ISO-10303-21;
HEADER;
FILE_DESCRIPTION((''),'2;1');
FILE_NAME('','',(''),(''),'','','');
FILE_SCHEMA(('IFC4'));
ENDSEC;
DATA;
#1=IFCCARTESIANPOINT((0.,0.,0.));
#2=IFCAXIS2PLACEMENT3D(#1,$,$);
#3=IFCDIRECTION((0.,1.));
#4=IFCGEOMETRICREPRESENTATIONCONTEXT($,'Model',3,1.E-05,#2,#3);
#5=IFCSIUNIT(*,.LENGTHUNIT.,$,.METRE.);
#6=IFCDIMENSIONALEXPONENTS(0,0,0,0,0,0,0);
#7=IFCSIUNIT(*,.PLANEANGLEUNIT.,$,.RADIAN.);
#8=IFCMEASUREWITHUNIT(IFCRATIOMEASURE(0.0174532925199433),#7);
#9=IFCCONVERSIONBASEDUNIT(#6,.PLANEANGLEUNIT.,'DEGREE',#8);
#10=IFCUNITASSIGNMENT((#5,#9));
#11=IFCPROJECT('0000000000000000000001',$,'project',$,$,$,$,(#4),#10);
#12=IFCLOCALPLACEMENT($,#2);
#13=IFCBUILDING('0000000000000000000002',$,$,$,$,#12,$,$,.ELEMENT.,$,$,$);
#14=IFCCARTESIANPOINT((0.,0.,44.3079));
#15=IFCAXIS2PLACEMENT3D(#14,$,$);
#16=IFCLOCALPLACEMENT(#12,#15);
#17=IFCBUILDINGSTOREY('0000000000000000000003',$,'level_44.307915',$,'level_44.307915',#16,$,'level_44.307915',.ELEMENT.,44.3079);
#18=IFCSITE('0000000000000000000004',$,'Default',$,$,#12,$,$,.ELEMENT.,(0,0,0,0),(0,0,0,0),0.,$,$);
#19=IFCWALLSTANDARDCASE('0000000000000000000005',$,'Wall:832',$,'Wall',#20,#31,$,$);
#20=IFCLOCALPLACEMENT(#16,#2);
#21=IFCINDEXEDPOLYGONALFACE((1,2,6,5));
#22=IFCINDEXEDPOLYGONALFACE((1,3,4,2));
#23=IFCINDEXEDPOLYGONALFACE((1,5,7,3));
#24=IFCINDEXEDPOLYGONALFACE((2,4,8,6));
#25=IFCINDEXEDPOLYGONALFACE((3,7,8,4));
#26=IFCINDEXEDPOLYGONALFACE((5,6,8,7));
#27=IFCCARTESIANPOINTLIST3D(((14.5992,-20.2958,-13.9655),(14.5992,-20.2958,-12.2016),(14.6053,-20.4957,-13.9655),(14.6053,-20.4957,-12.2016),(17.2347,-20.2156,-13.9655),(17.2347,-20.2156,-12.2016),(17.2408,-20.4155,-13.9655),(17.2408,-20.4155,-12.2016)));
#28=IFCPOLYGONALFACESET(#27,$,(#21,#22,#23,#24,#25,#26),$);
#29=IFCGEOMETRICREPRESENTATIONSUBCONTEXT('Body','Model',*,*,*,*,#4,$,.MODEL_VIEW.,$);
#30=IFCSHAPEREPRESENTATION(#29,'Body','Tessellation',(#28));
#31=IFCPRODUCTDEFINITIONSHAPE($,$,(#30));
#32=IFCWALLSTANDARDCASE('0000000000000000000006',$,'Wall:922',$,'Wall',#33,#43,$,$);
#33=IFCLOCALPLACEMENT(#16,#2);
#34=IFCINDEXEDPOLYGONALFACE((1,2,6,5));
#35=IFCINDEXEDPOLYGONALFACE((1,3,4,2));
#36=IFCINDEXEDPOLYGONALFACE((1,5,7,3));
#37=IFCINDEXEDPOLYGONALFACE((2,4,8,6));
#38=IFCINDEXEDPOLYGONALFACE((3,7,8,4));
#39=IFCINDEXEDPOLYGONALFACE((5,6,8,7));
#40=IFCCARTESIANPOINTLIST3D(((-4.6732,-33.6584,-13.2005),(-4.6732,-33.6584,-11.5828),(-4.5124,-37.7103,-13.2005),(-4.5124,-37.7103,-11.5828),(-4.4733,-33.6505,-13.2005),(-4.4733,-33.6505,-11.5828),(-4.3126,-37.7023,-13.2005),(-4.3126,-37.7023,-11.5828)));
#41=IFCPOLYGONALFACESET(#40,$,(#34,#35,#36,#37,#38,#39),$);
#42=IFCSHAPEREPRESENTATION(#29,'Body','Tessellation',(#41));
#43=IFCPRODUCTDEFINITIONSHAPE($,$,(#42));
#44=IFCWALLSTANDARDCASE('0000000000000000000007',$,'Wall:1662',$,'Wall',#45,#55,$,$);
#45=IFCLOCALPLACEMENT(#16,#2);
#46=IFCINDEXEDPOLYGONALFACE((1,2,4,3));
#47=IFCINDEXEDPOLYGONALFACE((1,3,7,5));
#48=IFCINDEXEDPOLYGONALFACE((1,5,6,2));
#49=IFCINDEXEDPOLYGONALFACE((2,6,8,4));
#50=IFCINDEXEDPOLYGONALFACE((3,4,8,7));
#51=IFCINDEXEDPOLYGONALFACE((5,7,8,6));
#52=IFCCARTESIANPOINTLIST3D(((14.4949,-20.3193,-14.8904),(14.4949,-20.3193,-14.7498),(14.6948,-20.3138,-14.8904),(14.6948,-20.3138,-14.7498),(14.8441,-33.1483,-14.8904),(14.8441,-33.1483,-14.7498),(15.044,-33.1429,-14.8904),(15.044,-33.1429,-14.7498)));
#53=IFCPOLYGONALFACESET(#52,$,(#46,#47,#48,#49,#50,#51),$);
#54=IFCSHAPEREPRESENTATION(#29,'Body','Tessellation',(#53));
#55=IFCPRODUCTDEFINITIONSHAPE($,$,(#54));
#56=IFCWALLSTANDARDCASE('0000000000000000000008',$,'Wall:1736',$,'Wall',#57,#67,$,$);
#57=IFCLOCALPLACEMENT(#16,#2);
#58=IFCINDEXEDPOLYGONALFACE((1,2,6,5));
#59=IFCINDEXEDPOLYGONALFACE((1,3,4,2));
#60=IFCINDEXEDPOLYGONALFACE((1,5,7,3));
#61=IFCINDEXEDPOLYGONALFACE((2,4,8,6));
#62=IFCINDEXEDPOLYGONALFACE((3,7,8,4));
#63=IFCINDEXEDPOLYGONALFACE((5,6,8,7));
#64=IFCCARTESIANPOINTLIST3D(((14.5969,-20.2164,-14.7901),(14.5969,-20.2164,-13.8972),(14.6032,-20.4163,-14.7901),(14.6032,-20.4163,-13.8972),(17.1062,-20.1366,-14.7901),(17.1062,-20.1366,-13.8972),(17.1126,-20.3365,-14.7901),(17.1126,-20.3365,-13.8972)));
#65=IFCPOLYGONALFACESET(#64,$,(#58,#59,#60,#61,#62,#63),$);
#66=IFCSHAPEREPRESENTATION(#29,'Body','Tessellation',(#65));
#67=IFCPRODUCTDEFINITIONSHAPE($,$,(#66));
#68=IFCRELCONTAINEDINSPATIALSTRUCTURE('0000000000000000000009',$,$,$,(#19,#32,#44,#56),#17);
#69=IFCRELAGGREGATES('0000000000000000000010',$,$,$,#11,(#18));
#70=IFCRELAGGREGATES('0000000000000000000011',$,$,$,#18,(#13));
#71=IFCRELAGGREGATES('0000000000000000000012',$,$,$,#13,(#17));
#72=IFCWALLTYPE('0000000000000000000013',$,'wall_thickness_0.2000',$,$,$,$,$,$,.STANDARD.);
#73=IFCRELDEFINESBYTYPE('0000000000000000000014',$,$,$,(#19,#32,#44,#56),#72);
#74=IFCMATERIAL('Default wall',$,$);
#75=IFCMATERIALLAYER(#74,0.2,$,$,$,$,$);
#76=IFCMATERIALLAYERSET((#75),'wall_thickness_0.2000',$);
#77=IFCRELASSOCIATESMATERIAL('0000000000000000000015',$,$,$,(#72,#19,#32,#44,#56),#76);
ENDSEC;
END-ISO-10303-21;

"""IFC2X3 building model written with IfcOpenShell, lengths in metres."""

from ifc_helpers import new_model, entity, si_unit, converted_unit, direction, frame, origin, place, context, subcontext, project, spatial, polyline, outline, extrude, material, layer, layer_set, layer_usage, type_object, element, save


model = new_model("IFC2X3")

# Units and contexts
model_context = context("Model", 3, precision=1e-05, world=origin(), true_north=direction((0.0, 1.0)))
body_context = subcontext(model_context, "Body", "Model", "MODEL_VIEW")
ifc_project = project(units=[si_unit("LENGTHUNIT", "METRE"), converted_unit("PLANEANGLEUNIT", "DEGREE", entity("IfcRatioMeasure", 0.0174532925199433), si_unit("PLANEANGLEUNIT", "RADIAN"), dimensions=[0, 0, 0, 0, 0, 0, 0])], contexts=[model_context])

# Site, building, storey
placement_1 = place(None, origin())
site = spatial("IfcSite", under=ifc_project, at=placement_1, Name="Default", CompositionType="ELEMENT", RefLatitude=(0, 0, 0, 0), RefLongitude=(0, 0, 0, 0), RefElevation=0.0)
building = spatial("IfcBuilding", under=site, at=placement_1, CompositionType="ELEMENT")
storey_placement = place(placement_1, frame((0.0, 0.0, 44.3079)))
storey = spatial("IfcBuildingStorey", under=building, at=storey_placement, Name="level_44.307915", ObjectType="level_44.307915", LongName="level_44.307915", CompositionType="ELEMENT", Elevation=44.3079)

# Walls
ifc_material = material(Name="Default wall")
ifc_layer = layer(ifc_material, 0.2)
ifc_layer_set = layer_set([ifc_layer], Name="wall_thickness_0.2000")
ifc_layer_usage = layer_usage(ifc_layer_set, "AXIS2", "POSITIVE", -0.1)
wall_type = type_object("IfcWallType", Name="wall_thickness_0.2000", PredefinedType="STANDARD", material=ifc_layer_set)
placement_2 = place(placement_1, frame((0.0, 0.0, 30.3424)))
wall_1_placement = place(placement_2, frame((14.6022, -20.3958, 0.0), z_axis=(0.0, 0.0, 1.0), x_axis=(0.999537, 0.030432, 0.0)))
element("IfcWallStandardCase", 1, at=wall_1_placement, inside=storey, type_object=wall_type, material=ifc_layer_usage, Name="Wall:832", ObjectType="Wall", context=body_context, shape_type="SweptSolid", body=[
    extrude(outline(polyline([(2.6367, -0.1), (2.6367, 0.1), (0.0, 0.1), (0.0, -0.1), (2.6367, -0.1)])), origin(), (0.0, 0.0, 1.0), 1.7639),
])
placement_3 = place(placement_1, frame((0.0, 0.0, 31.1074)))
wall_2_placement = place(placement_3, frame((-4.4125, -37.7063, 0.0), z_axis=(0.0, 0.0, 1.0), x_axis=(-0.039648, 0.999214, 0.0)))
element("IfcWallStandardCase", 2, at=wall_2_placement, inside=storey, type_object=wall_type, material=ifc_layer_usage, Name="Wall:922", ObjectType="Wall", context=body_context, shape_type="SweptSolid", body=[
    extrude(outline(polyline([(4.055, -0.1), (4.055, 0.1), (0.0, 0.1), (0.0, -0.1), (4.055, -0.1)])), origin(), (0.0, 0.0, 1.0), 1.6177),
])
placement_4 = place(placement_1, frame((0.0, 0.0, 29.4175)))
wall_3_placement = place(placement_4, frame((14.5949, -20.3166, 0.0), z_axis=(0.0, 0.0, 1.0), x_axis=(0.027208, -0.99963, 0.0)))
element("IfcWallStandardCase", 3, at=wall_3_placement, inside=storey, type_object=wall_type, material=ifc_layer_usage, Name="Wall:1662", ObjectType="Wall", context=body_context, shape_type="SweptSolid", body=[
    extrude(outline(polyline([(12.8338, -0.1), (12.8338, 0.1), (0.0, 0.1), (0.0, -0.1), (12.8338, -0.1)])), origin(), (0.0, 0.0, 1.0), 0.1405),
])
placement_5 = place(placement_1, frame((0.0, 0.0, 29.5178)))
wall_4_placement = place(placement_5, frame((14.6, -20.3164, 0.0), z_axis=(0.0, 0.0, 1.0), x_axis=(0.999495, 0.031786, 0.0)))
element("IfcWallStandardCase", 4, at=wall_4_placement, inside=storey, type_object=wall_type, material=ifc_layer_usage, Name="Wall:1736", ObjectType="Wall", context=body_context, shape_type="SweptSolid", body=[
    extrude(outline(polyline([(2.5106, -0.1), (2.5106, 0.1), (0.0, 0.1), (0.0, -0.1), (2.5106, -0.1)])), origin(), (0.0, 0.0, 1.0), 0.893),
])

save(model, "model.ifc")
